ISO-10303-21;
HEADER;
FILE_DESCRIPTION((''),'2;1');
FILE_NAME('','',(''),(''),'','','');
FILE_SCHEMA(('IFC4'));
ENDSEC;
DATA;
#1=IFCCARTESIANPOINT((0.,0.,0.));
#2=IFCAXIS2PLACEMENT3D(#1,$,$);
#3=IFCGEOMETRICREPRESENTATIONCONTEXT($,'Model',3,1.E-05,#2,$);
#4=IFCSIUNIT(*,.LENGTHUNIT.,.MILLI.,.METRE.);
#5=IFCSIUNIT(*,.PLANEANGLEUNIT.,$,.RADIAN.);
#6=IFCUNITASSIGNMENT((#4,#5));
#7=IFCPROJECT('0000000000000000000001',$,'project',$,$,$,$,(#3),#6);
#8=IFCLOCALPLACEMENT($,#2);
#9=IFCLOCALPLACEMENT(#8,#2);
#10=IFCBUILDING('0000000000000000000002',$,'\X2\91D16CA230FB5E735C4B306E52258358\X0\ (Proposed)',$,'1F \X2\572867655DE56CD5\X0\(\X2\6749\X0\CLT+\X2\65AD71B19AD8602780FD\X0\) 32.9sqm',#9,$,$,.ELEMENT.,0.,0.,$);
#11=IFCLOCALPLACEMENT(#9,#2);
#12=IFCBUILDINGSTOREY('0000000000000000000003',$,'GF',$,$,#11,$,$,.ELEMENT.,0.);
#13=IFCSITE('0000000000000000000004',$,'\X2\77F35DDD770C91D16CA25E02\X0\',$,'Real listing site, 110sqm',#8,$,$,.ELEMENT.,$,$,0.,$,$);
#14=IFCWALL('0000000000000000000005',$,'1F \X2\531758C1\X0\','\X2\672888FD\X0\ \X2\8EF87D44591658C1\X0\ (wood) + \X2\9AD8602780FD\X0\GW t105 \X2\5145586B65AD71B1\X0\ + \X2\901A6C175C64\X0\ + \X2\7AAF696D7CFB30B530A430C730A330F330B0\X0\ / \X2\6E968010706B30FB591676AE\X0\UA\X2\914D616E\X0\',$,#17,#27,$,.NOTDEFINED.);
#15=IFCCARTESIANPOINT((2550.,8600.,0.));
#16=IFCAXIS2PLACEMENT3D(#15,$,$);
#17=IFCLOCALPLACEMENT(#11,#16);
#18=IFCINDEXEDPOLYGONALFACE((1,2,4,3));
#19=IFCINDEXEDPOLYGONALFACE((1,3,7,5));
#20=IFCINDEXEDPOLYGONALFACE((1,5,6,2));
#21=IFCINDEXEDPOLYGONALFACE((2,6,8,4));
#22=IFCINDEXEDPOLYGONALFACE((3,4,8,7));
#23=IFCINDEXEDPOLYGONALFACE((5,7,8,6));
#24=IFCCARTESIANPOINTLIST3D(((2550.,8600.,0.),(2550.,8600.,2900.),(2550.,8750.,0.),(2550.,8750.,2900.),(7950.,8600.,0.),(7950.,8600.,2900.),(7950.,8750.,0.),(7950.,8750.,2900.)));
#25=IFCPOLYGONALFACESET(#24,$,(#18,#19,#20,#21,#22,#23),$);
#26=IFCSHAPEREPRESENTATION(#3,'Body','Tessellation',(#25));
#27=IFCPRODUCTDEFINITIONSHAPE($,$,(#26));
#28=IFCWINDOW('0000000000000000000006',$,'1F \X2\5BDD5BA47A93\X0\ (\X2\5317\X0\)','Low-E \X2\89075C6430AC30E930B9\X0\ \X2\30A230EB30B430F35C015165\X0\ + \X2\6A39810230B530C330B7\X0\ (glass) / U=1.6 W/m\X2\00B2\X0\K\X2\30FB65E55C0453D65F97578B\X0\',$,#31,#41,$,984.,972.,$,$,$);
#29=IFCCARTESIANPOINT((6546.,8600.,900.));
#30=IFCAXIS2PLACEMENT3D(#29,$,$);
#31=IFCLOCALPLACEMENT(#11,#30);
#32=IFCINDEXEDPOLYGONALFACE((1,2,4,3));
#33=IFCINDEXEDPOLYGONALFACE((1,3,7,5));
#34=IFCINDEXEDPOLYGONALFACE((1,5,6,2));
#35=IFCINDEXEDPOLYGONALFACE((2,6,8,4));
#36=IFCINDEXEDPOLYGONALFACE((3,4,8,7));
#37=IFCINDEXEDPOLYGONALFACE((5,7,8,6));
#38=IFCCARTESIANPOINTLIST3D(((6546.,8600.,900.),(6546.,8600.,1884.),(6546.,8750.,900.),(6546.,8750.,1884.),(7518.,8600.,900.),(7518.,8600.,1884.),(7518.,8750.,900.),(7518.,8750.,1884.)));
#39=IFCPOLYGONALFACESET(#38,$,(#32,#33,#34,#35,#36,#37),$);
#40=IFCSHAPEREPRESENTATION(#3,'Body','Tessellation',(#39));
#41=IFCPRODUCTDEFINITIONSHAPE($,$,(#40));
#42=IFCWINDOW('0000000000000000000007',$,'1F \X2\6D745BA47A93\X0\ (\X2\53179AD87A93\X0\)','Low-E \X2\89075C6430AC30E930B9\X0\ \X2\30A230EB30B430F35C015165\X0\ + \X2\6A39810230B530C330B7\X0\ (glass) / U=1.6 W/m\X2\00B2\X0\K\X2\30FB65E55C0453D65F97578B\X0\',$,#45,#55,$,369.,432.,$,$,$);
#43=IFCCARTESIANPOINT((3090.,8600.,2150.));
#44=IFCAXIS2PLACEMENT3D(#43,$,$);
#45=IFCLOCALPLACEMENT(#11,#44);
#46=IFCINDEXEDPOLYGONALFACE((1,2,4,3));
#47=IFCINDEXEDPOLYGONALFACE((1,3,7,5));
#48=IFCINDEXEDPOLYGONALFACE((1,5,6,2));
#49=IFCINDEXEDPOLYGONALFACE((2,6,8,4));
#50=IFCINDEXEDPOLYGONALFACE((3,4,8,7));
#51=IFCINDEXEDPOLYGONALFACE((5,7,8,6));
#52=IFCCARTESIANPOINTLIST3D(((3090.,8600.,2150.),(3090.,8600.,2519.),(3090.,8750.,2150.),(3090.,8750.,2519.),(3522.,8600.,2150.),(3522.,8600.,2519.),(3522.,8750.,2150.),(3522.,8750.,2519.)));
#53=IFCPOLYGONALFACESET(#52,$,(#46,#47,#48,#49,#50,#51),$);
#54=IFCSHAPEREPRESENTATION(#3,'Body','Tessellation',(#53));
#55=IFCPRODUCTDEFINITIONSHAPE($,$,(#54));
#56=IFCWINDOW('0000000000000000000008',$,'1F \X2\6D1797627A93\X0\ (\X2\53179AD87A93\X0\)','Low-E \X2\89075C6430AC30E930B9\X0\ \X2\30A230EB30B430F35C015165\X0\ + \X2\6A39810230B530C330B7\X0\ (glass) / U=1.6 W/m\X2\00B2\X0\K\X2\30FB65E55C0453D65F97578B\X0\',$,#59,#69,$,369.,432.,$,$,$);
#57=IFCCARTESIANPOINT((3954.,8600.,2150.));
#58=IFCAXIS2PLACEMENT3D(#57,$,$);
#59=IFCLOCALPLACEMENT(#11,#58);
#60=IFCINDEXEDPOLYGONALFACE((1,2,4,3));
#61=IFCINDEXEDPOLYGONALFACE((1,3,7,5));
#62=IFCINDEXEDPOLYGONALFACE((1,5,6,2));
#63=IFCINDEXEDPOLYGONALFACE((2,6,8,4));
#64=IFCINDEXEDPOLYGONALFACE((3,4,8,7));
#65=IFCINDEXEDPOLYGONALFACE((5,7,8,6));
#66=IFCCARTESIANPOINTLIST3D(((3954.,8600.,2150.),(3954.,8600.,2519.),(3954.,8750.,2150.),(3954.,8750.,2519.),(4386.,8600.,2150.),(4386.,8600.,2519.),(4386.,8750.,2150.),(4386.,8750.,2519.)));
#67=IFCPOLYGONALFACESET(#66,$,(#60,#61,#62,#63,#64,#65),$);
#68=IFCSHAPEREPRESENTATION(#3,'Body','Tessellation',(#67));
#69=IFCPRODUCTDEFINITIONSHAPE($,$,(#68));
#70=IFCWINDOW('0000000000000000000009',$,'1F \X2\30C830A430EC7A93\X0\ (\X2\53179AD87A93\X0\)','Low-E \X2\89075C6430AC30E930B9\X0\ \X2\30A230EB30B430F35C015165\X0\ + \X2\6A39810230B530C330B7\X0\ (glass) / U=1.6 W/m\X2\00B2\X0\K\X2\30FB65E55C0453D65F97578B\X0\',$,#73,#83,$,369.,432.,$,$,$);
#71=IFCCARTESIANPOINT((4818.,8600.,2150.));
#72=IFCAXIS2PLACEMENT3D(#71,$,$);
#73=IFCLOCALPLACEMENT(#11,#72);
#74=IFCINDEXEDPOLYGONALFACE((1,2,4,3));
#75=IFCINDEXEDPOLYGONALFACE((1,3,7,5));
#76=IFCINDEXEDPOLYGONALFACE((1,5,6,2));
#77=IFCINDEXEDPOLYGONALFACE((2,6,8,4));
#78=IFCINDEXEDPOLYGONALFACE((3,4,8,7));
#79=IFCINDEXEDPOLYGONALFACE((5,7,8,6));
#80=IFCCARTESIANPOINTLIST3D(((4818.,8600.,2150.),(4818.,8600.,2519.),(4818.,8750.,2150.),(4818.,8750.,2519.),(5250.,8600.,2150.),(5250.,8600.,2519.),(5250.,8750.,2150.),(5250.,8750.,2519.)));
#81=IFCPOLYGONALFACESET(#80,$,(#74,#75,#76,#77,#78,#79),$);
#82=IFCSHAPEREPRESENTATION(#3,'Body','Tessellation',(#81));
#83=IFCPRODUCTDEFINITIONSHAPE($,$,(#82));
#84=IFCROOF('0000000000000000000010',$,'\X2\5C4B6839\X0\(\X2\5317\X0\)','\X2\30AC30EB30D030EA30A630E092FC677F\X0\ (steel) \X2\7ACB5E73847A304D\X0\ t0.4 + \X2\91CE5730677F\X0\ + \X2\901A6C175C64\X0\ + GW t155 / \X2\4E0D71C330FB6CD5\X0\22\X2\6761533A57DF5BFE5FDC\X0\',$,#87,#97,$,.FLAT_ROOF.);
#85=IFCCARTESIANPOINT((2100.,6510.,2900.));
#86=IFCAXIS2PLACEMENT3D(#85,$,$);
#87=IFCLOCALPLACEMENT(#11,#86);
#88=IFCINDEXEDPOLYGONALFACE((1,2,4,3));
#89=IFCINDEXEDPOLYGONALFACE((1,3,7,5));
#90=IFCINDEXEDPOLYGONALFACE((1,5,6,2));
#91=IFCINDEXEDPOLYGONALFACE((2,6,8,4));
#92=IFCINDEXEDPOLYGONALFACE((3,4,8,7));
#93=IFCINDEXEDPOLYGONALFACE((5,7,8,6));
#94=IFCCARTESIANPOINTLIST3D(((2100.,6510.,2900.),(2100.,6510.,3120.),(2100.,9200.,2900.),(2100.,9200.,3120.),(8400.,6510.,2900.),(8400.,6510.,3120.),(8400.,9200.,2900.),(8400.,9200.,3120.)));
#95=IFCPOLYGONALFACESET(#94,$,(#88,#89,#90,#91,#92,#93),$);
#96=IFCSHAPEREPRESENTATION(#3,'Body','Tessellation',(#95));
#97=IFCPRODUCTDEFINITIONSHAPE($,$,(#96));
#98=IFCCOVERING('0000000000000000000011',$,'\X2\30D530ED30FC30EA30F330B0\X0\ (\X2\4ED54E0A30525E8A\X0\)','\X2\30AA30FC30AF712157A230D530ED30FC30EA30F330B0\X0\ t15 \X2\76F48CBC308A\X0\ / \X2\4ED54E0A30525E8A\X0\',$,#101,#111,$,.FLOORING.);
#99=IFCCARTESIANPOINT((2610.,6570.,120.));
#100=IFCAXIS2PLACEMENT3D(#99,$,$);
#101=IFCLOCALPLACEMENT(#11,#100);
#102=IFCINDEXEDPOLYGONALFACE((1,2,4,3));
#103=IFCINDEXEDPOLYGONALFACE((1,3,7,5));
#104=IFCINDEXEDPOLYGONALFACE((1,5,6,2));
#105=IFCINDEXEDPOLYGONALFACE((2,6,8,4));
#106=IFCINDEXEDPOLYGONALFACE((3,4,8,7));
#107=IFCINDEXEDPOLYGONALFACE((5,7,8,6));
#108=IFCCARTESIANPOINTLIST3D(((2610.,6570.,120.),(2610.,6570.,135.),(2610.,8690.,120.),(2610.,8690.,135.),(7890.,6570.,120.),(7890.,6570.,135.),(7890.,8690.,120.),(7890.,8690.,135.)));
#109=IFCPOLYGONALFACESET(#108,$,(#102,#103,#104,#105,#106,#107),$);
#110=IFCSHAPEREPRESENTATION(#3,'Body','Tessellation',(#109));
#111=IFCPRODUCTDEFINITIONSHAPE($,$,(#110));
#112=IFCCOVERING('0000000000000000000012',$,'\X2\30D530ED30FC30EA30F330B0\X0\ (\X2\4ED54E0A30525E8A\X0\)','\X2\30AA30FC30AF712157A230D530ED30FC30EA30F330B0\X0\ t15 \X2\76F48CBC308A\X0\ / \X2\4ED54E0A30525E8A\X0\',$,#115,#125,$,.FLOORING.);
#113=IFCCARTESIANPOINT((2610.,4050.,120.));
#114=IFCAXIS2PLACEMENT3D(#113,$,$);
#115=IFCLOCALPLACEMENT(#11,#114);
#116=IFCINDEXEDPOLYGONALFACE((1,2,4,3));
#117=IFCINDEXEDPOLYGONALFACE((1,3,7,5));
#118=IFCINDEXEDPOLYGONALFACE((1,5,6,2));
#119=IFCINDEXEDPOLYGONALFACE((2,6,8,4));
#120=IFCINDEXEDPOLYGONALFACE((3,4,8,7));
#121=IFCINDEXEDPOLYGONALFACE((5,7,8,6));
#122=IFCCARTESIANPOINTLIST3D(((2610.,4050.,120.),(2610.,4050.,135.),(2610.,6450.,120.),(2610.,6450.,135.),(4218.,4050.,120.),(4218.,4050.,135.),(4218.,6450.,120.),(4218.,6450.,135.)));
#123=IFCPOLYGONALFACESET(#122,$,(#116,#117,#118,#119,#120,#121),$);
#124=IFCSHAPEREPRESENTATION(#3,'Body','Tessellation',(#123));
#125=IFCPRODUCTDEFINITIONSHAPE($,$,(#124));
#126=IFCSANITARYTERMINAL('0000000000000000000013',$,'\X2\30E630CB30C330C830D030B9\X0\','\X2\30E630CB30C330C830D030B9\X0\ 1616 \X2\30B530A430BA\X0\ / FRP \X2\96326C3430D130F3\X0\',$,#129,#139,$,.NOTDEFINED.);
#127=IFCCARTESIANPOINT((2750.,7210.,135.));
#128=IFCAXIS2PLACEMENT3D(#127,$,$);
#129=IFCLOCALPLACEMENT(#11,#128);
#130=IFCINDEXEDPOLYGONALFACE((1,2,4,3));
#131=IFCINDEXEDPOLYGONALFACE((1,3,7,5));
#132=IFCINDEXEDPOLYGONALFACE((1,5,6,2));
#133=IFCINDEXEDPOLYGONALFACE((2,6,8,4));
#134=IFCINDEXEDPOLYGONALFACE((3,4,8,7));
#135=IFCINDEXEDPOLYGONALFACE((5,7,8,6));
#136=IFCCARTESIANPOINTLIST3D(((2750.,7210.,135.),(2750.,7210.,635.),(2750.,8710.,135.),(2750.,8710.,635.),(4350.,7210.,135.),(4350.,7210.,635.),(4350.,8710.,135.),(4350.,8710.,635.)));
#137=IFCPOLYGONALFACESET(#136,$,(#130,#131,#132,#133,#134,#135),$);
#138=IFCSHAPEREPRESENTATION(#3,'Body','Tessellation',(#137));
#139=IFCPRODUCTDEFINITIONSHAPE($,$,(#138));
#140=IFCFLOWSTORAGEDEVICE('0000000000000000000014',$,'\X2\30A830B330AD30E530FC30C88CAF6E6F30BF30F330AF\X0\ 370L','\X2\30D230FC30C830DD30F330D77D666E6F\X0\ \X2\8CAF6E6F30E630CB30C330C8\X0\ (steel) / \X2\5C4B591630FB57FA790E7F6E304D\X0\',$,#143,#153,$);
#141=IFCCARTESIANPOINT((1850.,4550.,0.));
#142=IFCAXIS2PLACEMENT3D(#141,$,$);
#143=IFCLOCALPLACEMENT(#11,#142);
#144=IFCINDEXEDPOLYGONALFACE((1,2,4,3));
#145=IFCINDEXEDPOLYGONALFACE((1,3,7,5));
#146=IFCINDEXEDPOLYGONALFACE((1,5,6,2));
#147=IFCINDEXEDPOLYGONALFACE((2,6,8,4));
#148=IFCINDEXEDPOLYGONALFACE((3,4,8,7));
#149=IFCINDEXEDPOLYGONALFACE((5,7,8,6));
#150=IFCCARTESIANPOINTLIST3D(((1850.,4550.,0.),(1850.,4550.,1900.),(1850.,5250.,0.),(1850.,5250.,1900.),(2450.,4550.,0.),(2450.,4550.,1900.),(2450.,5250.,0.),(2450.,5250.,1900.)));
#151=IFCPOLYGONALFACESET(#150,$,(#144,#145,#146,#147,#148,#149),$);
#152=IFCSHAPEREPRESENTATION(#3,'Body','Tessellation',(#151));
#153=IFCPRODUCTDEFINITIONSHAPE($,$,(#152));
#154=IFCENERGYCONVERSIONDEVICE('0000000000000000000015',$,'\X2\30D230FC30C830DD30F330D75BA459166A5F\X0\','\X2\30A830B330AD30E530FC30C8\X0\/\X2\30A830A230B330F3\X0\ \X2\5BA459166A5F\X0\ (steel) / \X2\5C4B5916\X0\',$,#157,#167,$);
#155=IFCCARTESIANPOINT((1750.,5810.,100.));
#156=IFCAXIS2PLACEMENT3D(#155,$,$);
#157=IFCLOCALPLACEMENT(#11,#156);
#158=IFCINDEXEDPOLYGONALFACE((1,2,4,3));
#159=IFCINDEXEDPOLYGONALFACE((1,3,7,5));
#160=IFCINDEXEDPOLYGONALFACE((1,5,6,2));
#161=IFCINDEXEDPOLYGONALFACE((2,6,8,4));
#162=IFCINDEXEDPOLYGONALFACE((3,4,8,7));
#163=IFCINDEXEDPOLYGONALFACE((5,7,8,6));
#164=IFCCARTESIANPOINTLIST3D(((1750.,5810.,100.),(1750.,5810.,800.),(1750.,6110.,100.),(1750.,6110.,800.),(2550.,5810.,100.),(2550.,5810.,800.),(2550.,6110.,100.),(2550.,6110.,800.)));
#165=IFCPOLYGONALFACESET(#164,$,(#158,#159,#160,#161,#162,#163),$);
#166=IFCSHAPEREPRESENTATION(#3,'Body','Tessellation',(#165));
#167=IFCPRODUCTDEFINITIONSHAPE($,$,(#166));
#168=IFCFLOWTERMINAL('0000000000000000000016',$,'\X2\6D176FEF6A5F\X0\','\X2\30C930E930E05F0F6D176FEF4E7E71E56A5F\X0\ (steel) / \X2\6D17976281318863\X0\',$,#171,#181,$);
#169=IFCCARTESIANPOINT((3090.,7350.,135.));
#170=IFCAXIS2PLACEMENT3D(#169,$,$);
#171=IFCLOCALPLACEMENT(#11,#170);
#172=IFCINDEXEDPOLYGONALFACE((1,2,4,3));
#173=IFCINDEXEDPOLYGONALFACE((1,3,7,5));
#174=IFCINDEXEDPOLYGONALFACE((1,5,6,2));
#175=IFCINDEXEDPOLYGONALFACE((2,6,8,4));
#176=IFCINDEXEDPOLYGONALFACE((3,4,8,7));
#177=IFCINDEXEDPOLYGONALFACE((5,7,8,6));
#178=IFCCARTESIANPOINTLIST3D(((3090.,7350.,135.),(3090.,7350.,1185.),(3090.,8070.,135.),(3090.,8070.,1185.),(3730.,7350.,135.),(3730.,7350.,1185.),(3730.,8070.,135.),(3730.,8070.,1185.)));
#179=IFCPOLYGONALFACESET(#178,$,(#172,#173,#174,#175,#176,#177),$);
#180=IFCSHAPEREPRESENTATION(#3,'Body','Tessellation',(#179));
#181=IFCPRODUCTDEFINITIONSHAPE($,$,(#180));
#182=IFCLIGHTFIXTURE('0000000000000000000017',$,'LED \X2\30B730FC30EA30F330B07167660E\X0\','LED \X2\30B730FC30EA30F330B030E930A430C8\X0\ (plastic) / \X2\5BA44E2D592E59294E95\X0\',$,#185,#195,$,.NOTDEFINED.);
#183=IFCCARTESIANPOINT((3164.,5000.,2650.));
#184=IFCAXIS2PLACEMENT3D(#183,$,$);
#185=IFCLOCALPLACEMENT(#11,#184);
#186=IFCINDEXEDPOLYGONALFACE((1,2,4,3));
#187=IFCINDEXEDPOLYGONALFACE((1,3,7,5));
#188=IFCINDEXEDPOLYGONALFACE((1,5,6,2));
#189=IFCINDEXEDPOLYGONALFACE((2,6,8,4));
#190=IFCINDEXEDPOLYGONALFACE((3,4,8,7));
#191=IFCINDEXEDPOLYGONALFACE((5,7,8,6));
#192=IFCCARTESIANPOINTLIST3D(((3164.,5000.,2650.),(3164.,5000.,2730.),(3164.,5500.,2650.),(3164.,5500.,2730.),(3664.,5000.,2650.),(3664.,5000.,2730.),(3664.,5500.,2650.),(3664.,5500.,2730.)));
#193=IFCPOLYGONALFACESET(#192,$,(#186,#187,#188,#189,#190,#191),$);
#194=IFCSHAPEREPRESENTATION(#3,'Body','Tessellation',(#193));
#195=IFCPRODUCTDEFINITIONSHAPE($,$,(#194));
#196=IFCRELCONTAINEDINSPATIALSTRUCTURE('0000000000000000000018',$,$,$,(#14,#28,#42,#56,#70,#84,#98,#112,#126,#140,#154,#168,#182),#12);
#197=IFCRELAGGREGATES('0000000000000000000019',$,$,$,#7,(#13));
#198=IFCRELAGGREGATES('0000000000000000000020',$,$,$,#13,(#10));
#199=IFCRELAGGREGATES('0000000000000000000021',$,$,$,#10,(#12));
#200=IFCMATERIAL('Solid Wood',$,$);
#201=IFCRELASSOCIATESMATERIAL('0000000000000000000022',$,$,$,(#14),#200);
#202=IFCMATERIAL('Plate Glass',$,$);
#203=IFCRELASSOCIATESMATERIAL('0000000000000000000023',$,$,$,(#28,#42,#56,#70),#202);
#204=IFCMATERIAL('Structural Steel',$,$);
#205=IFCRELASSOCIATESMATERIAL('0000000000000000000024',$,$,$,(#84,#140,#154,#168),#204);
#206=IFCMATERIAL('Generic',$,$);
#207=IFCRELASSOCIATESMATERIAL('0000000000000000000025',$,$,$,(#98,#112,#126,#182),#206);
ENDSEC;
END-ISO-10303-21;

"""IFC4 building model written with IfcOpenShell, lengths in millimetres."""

from ifc_helpers import new_model, si_unit, frame, frame_2d, origin, place, context, project, spatial, rectangle, extrude, material, element, fill, save


model = new_model("IFC4")

# Units and contexts
model_context = context("Model", 3, precision=1e-05, world=origin())
ifc_project = project(units=[si_unit("LENGTHUNIT", "METRE", prefix="MILLI"), si_unit("PLANEANGLEUNIT", "RADIAN")], contexts=[model_context])

# Site, building, storey
site_placement = place(None, origin())
site = spatial("IfcSite", under=ifc_project, at=site_placement, Name="石川県金沢市", ObjectType="Real listing site, 110sqm", CompositionType="ELEMENT", RefElevation=0.0)
building_placement = place(site_placement, origin())
building = spatial("IfcBuilding", under=site, at=building_placement, Name="金沢・平屋の別荘 (Proposed)", ObjectType="1F 在来工法(杉CLT+断熱高性能) 32.9sqm", CompositionType="ELEMENT", ElevationOfRefHeight=0.0, ElevationOfTerrain=0.0)
storey_placement = place(building_placement, origin())
storey = spatial("IfcBuildingStorey", under=building, at=storey_placement, Name="GF", CompositionType="ELEMENT", Elevation=0.0)

# Shared definitions
ifc_material_1 = material(Name="Solid Wood")

# Wall, openings, windows
wall_1_placement = place(storey_placement, frame((2550.0, 8600.0, 0.0)))
wall_1 = element("IfcWall", 1, at=wall_1_placement, inside=storey, material=ifc_material_1, Name="1F 北壁", Description="木製 軸組外壁 (wood) + 高性能GW t105 充填断熱 + 通気層 + 窯業系サイディング / 準耐火・外皮UA配慮", PredefinedType="NOTDEFINED", context=model_context, shape_type="SweptSolid", body=[
    extrude(rectangle(XDim=5400.0, YDim=150.0, at=frame_2d((2700.0, 75.0))), frame((2550.0, 8600.0, 0.0)), (0.0, 0.0, 1.0), 2900.0),
])
opening_1_placement = place(storey_placement, frame((6546.0, 8600.0, 900.0)))
opening_1 = element("IfcOpeningElement", 2, at=opening_1_placement, cuts=wall_1, PredefinedType="NOTDEFINED", context=model_context, shape_type="SweptSolid", body=[
    extrude(rectangle(XDim=972.0, YDim=150.0, at=frame_2d((486.0, 75.0))), frame((6546.0, 8600.0, 900.0)), (0.0, 0.0, 1.0), 984.0),
])
opening_2_placement = place(storey_placement, frame((3090.0, 8600.0, 2150.0)))
opening_2 = element("IfcOpeningElement", 3, at=opening_2_placement, cuts=wall_1, PredefinedType="NOTDEFINED", context=model_context, shape_type="SweptSolid", body=[
    extrude(rectangle(XDim=432.0, YDim=150.0, at=frame_2d((216.0, 75.0))), frame((3090.0, 8600.0, 2150.0)), (0.0, 0.0, 1.0), 369.0),
])
opening_3_placement = place(storey_placement, frame((3954.0, 8600.0, 2150.0)))
opening_3 = element("IfcOpeningElement", 4, at=opening_3_placement, cuts=wall_1, PredefinedType="NOTDEFINED", context=model_context, shape_type="SweptSolid", body=[
    extrude(rectangle(XDim=432.0, YDim=150.0, at=frame_2d((216.0, 75.0))), frame((3954.0, 8600.0, 2150.0)), (0.0, 0.0, 1.0), 369.0),
])
opening_4_placement = place(storey_placement, frame((4818.0, 8600.0, 2150.0)))
opening_4 = element("IfcOpeningElement", 5, at=opening_4_placement, cuts=wall_1, PredefinedType="NOTDEFINED", context=model_context, shape_type="SweptSolid", body=[
    extrude(rectangle(XDim=432.0, YDim=150.0, at=frame_2d((216.0, 75.0))), frame((4818.0, 8600.0, 2150.0)), (0.0, 0.0, 1.0), 369.0),
])
ifc_material_2 = material(Name="Plate Glass")
window_1_placement = place(storey_placement, frame((6546.0, 8600.0, 900.0)))
window_1 = element("IfcWindow", 6, at=window_1_placement, inside=storey, material=ifc_material_2, Name="1F 寝室窓 (北)", Description="Low-E 複層ガラス アルゴン封入 + 樹脂サッシ (glass) / U=1.6 W/m²K・日射取得型", OverallHeight=984.0, OverallWidth=972.0, context=model_context, shape_type="SweptSolid", body=[
    extrude(rectangle(XDim=972.0, YDim=150.0, at=frame_2d((486.0, 75.0))), frame((6546.0, 8600.0, 900.0)), (0.0, 0.0, 1.0), 984.0),
])
fill(opening_1, window_1)
window_2_placement = place(storey_placement, frame((3090.0, 8600.0, 2150.0)))
window_2 = element("IfcWindow", 7, at=window_2_placement, inside=storey, material=ifc_material_2, Name="1F 浴室窓 (北高窓)", Description="Low-E 複層ガラス アルゴン封入 + 樹脂サッシ (glass) / U=1.6 W/m²K・日射取得型", OverallHeight=369.0, OverallWidth=432.0, context=model_context, shape_type="SweptSolid", body=[
    extrude(rectangle(XDim=432.0, YDim=150.0, at=frame_2d((216.0, 75.0))), frame((3090.0, 8600.0, 2150.0)), (0.0, 0.0, 1.0), 369.0),
])
fill(opening_2, window_2)
window_3_placement = place(storey_placement, frame((3954.0, 8600.0, 2150.0)))
window_3 = element("IfcWindow", 8, at=window_3_placement, inside=storey, material=ifc_material_2, Name="1F 洗面窓 (北高窓)", Description="Low-E 複層ガラス アルゴン封入 + 樹脂サッシ (glass) / U=1.6 W/m²K・日射取得型", OverallHeight=369.0, OverallWidth=432.0, context=model_context, shape_type="SweptSolid", body=[
    extrude(rectangle(XDim=432.0, YDim=150.0, at=frame_2d((216.0, 75.0))), frame((3954.0, 8600.0, 2150.0)), (0.0, 0.0, 1.0), 369.0),
])
fill(opening_3, window_3)
window_4_placement = place(storey_placement, frame((4818.0, 8600.0, 2150.0)))
window_4 = element("IfcWindow", 9, at=window_4_placement, inside=storey, material=ifc_material_2, Name="1F トイレ窓 (北高窓)", Description="Low-E 複層ガラス アルゴン封入 + 樹脂サッシ (glass) / U=1.6 W/m²K・日射取得型", OverallHeight=369.0, OverallWidth=432.0, context=model_context, shape_type="SweptSolid", body=[
    extrude(rectangle(XDim=432.0, YDim=150.0, at=frame_2d((216.0, 75.0))), frame((4818.0, 8600.0, 2150.0)), (0.0, 0.0, 1.0), 369.0),
])
fill(opening_4, window_4)

# Roof
ifc_material_3 = material(Name="Structural Steel")
roof_placement = place(storey_placement, frame((2100.0, 6510.0, 2900.0)))
element("IfcRoof", 10, at=roof_placement, inside=storey, material=ifc_material_3, Name="屋根(北)", Description="ガルバリウム鋼板 (steel) 立平葺き t0.4 + 野地板 + 通気層 + GW t155 / 不燃・法22条区域対応", PredefinedType="FLAT_ROOF", context=model_context, shape_type="SweptSolid", body=[
    extrude(rectangle(XDim=6300.0, YDim=2690.0, at=frame_2d((3150.0, 1345.0))), frame((2100.0, 6510.0, 2900.0)), (0.0, 0.0, 1.0), 220.0),
])

# Coverings
ifc_material_4 = material(Name="Generic")
covering_1_placement = place(storey_placement, frame((2610.0, 6570.0, 120.0)))
element("IfcCovering", 11, at=covering_1_placement, inside=storey, material=ifc_material_4, Name="フローリング (仕上げ床)", Description="オーク無垢フローリング t15 直貼り / 仕上げ床", PredefinedType="FLOORING", context=model_context, shape_type="SweptSolid", body=[
    extrude(rectangle(XDim=5280.0, YDim=2120.0, at=frame_2d((2640.0, 1060.0))), frame((2610.0, 6570.0, 120.0)), (0.0, 0.0, 1.0), 15.0),
])
covering_2_placement = place(storey_placement, frame((2610.0, 4050.0, 120.0)))
element("IfcCovering", 12, at=covering_2_placement, inside=storey, material=ifc_material_4, Name="フローリング (仕上げ床)", Description="オーク無垢フローリング t15 直貼り / 仕上げ床", PredefinedType="FLOORING", context=model_context, shape_type="SweptSolid", body=[
    extrude(rectangle(XDim=1608.0, YDim=2400.0, at=frame_2d((804.0, 1200.0))), frame((2610.0, 4050.0, 120.0)), (0.0, 0.0, 1.0), 15.0),
])

# Sanitary terminal
sanitary_terminal_placement = place(storey_placement, frame((2750.0, 7210.0, 135.0)))
element("IfcSanitaryTerminal", 13, at=sanitary_terminal_placement, inside=storey, material=ifc_material_4, Name="ユニットバス", Description="ユニットバス 1616 サイズ / FRP 防水パン", PredefinedType="NOTDEFINED", context=model_context, shape_type="SweptSolid", body=[
    extrude(rectangle(XDim=1600.0, YDim=1500.0, at=frame_2d((800.0, 750.0))), frame((2750.0, 7210.0, 135.0)), (0.0, 0.0, 1.0), 500.0),
])

# Flow storage device
flow_storage_device_placement = place(storey_placement, frame((1850.0, 4550.0, 0.0)))
element("IfcFlowStorageDevice", 14, at=flow_storage_device_placement, inside=storey, material=ifc_material_3, Name="エコキュート貯湯タンク 370L", Description="ヒートポンプ給湯 貯湯ユニット (steel) / 屋外・基礎置き", context=model_context, shape_type="SweptSolid", body=[
    extrude(rectangle(XDim=600.0, YDim=700.0, at=frame_2d((300.0, 350.0))), frame((1850.0, 4550.0, 0.0)), (0.0, 0.0, 1.0), 1900.0),
])

# Energy conversion device
energy_conversion_device_placement = place(storey_placement, frame((1750.0, 5810.0, 100.0)))
element("IfcEnergyConversionDevice", 15, at=energy_conversion_device_placement, inside=storey, material=ifc_material_3, Name="ヒートポンプ室外機", Description="エコキュート/エアコン 室外機 (steel) / 屋外", context=model_context, shape_type="SweptSolid", body=[
    extrude(rectangle(XDim=800.0, YDim=300.0, at=frame_2d((400.0, 150.0))), frame((1750.0, 5810.0, 100.0)), (0.0, 0.0, 1.0), 700.0),
])

# Flow terminal
flow_terminal_placement = place(storey_placement, frame((3090.0, 7350.0, 135.0)))
element("IfcFlowTerminal", 16, at=flow_terminal_placement, inside=storey, material=ifc_material_3, Name="洗濯機", Description="ドラム式洗濯乾燥機 (steel) / 洗面脱衣", context=model_context, shape_type="SweptSolid", body=[
    extrude(rectangle(XDim=640.0, YDim=720.0, at=frame_2d((320.0, 360.0))), frame((3090.0, 7350.0, 135.0)), (0.0, 0.0, 1.0), 1050.0),
])

# Light fixture
light_fixture_placement = place(storey_placement, frame((3164.0, 5000.0, 2650.0)))
element("IfcLightFixture", 17, at=light_fixture_placement, inside=storey, material=ifc_material_4, Name="LED シーリング照明", Description="LED シーリングライト (plastic) / 室中央天井", PredefinedType="NOTDEFINED", context=model_context, shape_type="SweptSolid", body=[
    extrude(rectangle(XDim=500.0, YDim=500.0, at=frame_2d((250.0, 250.0))), frame((3164.0, 5000.0, 2650.0)), (0.0, 0.0, 1.0), 80.0),
])

save(model, "model.ifc")
